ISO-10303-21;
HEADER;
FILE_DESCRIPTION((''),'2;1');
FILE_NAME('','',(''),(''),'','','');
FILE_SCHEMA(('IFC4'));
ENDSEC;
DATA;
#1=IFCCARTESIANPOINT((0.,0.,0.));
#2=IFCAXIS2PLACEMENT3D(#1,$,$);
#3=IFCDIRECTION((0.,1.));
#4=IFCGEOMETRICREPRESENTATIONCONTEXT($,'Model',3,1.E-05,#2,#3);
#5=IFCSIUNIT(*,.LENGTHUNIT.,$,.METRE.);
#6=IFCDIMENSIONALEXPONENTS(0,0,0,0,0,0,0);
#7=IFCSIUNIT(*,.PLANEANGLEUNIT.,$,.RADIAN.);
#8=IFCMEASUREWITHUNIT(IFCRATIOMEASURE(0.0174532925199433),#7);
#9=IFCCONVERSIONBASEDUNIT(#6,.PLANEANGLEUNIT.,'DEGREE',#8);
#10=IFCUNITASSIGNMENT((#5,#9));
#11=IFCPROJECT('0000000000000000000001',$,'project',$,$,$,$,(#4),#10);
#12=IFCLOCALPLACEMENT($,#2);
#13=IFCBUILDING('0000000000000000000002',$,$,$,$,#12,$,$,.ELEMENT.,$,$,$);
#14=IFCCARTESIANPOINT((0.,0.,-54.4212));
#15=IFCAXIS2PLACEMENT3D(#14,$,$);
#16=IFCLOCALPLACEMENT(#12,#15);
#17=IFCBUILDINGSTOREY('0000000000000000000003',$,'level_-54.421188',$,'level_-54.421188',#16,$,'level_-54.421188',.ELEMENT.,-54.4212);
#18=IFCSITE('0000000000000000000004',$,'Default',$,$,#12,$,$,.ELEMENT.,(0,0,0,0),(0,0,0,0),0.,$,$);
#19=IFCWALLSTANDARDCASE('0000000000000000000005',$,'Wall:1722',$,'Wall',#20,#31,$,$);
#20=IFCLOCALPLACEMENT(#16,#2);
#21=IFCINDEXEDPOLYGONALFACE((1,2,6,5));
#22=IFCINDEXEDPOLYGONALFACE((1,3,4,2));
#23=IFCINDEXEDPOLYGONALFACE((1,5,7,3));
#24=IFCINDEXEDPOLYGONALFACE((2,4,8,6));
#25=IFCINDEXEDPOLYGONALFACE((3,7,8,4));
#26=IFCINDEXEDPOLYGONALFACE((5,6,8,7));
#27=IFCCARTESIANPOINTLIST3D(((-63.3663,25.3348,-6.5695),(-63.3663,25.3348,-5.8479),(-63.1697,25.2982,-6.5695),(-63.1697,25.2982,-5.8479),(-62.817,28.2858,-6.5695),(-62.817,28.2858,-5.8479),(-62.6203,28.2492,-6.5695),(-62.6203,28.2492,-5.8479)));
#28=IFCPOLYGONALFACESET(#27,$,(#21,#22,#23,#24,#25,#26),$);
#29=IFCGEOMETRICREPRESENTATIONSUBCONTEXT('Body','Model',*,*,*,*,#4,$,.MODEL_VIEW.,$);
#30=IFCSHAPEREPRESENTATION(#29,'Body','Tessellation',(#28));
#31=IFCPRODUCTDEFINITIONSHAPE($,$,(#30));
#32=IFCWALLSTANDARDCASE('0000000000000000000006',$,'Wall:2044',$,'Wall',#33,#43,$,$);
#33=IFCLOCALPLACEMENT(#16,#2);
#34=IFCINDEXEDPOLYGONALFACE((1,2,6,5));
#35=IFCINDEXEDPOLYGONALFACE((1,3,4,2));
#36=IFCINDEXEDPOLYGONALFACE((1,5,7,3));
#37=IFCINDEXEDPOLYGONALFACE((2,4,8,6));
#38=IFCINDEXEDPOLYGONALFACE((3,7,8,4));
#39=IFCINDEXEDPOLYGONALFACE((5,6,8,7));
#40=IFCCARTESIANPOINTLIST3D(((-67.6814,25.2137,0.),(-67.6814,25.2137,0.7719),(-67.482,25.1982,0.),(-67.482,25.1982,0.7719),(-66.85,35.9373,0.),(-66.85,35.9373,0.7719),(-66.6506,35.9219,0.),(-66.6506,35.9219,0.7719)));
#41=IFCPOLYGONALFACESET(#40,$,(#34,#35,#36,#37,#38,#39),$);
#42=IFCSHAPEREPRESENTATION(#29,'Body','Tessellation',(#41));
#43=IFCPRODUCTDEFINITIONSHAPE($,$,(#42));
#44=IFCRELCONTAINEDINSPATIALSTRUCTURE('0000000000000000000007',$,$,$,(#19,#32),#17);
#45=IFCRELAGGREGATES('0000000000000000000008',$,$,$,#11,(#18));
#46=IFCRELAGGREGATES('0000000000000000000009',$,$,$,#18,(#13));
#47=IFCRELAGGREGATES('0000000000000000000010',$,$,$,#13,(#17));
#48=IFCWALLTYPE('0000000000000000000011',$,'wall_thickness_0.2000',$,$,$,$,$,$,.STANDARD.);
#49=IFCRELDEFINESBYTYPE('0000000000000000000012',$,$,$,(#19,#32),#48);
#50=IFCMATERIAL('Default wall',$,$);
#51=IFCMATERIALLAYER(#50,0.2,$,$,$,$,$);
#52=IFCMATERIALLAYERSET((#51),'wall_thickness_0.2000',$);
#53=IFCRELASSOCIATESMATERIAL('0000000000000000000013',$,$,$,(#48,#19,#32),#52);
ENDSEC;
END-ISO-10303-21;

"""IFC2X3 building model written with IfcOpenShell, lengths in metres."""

from ifc_helpers import new_model, entity, si_unit, converted_unit, direction, frame, origin, place, context, subcontext, project, spatial, polyline, outline, extrude, material, layer, layer_set, layer_usage, type_object, element, save


model = new_model("IFC2X3")

# Units and contexts
model_context = context("Model", 3, precision=1e-05, world=origin(), true_north=direction((0.0, 1.0)))
body_context = subcontext(model_context, "Body", "Model", "MODEL_VIEW")
ifc_project = project(units=[si_unit("LENGTHUNIT", "METRE"), converted_unit("PLANEANGLEUNIT", "DEGREE", entity("IfcRatioMeasure", 0.0174532925199433), si_unit("PLANEANGLEUNIT", "RADIAN"), dimensions=[0, 0, 0, 0, 0, 0, 0])], contexts=[model_context])

# Site, building, storey
placement_1 = place(None, origin())
site = spatial("IfcSite", under=ifc_project, at=placement_1, Name="Default", CompositionType="ELEMENT", RefLatitude=(0, 0, 0, 0), RefLongitude=(0, 0, 0, 0), RefElevation=0.0)
building = spatial("IfcBuilding", under=site, at=placement_1, CompositionType="ELEMENT")
storey_placement = place(placement_1, frame((0.0, 0.0, -54.4212)))
storey = spatial("IfcBuildingStorey", under=building, at=storey_placement, Name="level_-54.421188", ObjectType="level_-54.421188", LongName="level_-54.421188", CompositionType="ELEMENT", Elevation=-54.4212)

# Shared definitions
ifc_material_1 = material(Name="Default wall")
ifc_layer = layer(ifc_material_1, 0.2)
ifc_layer_set = layer_set([ifc_layer], Name="wall_thickness_0.2000")
ifc_layer_usage = layer_usage(ifc_layer_set, "AXIS2", "POSITIVE", -0.1)
wall_type = type_object("IfcWallType", Name="wall_thickness_0.2000", PredefinedType="STANDARD", material=ifc_layer_set)

# Walls
placement_2 = place(placement_1, frame((0.0, 0.0, -60.9907)))
wall_1_placement = place(placement_2, frame((-63.268, 25.3165, 0.0), z_axis=(0.0, 0.0, 1.0), x_axis=(0.183006, 0.983112, 0.0)))
element("IfcWallStandardCase", 1, at=wall_1_placement, inside=storey, type_object=wall_type, material=ifc_layer_usage, Name="Wall:1722", ObjectType="Wall", context=body_context, shape_type="SweptSolid", body=[
    extrude(outline(polyline([(3.0017, -0.1), (3.0017, 0.1), (0.0, 0.1), (0.0, -0.1), (3.0017, -0.1)])), origin(), (0.0, 0.0, 1.0), 0.7215),
])
wall_2_placement = place(storey_placement, frame((-67.5817, 25.206, 0.0), z_axis=(0.0, 0.0, 1.0), x_axis=(0.077297, 0.997008, 0.0)))
element("IfcWallStandardCase", 2, at=wall_2_placement, inside=storey, type_object=wall_type, material=ifc_layer_usage, Name="Wall:2044", ObjectType="Wall", context=body_context, shape_type="SweptSolid", body=[
    extrude(outline(polyline([(10.7558, -0.1), (10.7558, 0.1), (0.0, 0.1), (0.0, -0.1), (10.7558, -0.1)])), origin(), (0.0, 0.0, 1.0), 0.7719),
])

save(model, "model.ifc")
